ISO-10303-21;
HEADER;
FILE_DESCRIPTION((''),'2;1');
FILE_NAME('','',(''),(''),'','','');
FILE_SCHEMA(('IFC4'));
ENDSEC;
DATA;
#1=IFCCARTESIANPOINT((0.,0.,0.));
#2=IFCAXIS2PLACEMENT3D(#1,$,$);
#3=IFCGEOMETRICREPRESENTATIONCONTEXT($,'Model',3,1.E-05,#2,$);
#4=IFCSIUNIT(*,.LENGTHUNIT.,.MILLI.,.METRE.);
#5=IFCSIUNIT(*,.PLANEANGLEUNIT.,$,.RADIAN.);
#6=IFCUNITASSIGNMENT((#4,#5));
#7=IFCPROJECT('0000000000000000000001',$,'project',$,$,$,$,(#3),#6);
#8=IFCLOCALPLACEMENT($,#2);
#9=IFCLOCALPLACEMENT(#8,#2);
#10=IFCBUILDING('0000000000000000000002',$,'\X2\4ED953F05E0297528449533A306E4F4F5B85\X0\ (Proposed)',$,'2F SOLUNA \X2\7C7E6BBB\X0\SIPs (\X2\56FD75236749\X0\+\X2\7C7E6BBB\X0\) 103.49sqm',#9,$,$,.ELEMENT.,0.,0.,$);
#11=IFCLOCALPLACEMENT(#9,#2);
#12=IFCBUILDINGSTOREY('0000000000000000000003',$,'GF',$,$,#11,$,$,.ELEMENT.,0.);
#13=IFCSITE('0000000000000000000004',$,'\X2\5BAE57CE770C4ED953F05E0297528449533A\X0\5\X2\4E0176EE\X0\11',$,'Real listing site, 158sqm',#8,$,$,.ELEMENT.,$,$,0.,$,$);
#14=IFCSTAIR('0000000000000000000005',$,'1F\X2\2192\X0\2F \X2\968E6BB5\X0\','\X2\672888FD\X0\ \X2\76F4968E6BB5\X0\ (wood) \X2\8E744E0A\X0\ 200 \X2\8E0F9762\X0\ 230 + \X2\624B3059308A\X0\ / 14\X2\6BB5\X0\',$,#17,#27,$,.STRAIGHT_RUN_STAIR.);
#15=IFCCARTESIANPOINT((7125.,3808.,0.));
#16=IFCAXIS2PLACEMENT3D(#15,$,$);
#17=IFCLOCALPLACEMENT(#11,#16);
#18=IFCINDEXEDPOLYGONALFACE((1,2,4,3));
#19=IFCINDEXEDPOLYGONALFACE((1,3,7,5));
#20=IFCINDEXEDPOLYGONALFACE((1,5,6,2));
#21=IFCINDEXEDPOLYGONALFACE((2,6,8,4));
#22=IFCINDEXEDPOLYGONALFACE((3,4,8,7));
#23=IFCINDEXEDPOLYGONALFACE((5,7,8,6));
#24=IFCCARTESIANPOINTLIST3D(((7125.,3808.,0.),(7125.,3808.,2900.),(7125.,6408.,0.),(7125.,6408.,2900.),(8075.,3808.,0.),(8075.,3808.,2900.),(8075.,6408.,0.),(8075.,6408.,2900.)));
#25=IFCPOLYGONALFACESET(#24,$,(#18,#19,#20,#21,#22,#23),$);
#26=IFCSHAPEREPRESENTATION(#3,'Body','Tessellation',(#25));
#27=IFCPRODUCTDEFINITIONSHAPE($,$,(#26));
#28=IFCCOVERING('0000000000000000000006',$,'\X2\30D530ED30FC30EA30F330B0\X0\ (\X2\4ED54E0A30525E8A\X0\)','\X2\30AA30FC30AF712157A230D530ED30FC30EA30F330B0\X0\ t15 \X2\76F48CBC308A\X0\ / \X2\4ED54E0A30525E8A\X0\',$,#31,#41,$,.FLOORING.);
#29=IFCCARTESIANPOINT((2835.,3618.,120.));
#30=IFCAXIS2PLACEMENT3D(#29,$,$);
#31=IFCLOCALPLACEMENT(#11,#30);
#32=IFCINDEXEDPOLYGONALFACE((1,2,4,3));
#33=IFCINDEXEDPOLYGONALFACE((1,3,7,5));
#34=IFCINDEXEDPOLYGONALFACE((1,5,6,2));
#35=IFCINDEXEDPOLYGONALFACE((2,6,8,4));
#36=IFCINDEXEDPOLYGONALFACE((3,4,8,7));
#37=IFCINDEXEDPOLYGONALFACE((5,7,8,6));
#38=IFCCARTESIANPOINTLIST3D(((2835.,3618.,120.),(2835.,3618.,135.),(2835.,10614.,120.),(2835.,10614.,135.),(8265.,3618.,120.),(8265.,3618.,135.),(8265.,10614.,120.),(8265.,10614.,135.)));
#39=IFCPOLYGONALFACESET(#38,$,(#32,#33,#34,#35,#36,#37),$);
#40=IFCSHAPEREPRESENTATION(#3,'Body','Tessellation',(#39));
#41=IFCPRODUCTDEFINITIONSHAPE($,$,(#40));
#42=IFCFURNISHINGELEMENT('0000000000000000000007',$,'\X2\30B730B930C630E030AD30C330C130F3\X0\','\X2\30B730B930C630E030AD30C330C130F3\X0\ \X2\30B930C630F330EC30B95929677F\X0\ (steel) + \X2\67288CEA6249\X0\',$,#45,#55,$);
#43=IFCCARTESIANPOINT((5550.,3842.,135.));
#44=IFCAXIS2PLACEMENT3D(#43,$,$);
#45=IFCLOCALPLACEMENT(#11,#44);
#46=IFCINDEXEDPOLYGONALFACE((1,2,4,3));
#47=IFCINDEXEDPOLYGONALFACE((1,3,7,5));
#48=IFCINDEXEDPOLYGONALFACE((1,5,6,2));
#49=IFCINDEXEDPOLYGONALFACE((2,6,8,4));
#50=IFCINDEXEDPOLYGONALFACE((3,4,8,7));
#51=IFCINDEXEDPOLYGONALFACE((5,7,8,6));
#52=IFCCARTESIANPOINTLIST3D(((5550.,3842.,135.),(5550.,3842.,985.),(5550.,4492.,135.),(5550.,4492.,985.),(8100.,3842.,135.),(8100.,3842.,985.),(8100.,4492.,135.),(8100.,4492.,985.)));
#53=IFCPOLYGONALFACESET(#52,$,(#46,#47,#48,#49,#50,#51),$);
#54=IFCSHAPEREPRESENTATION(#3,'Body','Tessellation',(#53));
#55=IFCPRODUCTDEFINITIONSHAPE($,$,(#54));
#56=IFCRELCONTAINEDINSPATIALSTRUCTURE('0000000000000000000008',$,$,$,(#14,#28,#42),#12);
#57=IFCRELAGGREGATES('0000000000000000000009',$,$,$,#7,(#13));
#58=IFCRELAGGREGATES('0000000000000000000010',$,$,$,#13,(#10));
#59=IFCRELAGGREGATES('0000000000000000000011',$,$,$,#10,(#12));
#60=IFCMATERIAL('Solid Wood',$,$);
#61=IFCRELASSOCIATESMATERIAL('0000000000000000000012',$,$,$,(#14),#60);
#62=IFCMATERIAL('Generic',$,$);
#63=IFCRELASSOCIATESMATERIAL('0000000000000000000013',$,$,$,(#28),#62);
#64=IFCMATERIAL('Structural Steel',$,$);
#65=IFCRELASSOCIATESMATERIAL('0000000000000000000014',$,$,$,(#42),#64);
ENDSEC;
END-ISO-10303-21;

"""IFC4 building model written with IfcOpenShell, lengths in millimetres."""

from ifc_helpers import new_model, si_unit, frame, frame_2d, origin, place, context, project, spatial, rectangle, extrude, material, element, save


model = new_model("IFC4")

# Units and contexts
model_context = context("Model", 3, precision=1e-05, world=origin())
ifc_project = project(units=[si_unit("LENGTHUNIT", "METRE", prefix="MILLI"), si_unit("PLANEANGLEUNIT", "RADIAN")], contexts=[model_context])

# Site, building, storey
site_placement = place(None, origin())
site = spatial("IfcSite", under=ifc_project, at=site_placement, Name="宮城県仙台市青葉区5丁目11", ObjectType="Real listing site, 158sqm", CompositionType="ELEMENT", RefElevation=0.0)
building_placement = place(site_placement, origin())
building = spatial("IfcBuilding", under=site, at=building_placement, Name="仙台市青葉区の住宅 (Proposed)", ObjectType="2F SOLUNA 籾殻SIPs (国産杉+籾殻) 103.49sqm", CompositionType="ELEMENT", ElevationOfRefHeight=0.0, ElevationOfTerrain=0.0)
storey_placement = place(building_placement, origin())
storey = spatial("IfcBuildingStorey", under=building, at=storey_placement, Name="GF", CompositionType="ELEMENT", Elevation=0.0)

# Shared definitions
ifc_material_1 = material(Name="Solid Wood")
ifc_material_2 = material(Name="Generic")

# Stair
stair_placement = place(storey_placement, frame((7125.0, 3808.0, 0.0)))
element("IfcStair", 1, at=stair_placement, inside=storey, material=ifc_material_1, Name="1F→2F 階段", Description="木製 直階段 (wood) 蹴上 200 踏面 230 + 手すり / 14段", PredefinedType="STRAIGHT_RUN_STAIR", context=model_context, shape_type="SweptSolid", body=[
    extrude(rectangle(XDim=950.0, YDim=2600.0, at=frame_2d((475.0, 1300.0))), frame((7125.0, 3808.0, 0.0)), (0.0, 0.0, 1.0), 2900.0),
])

# Covering
covering_placement = place(storey_placement, frame((2835.0, 3618.0, 120.0)))
element("IfcCovering", 2, at=covering_placement, inside=storey, material=ifc_material_2, Name="フローリング (仕上げ床)", Description="オーク無垢フローリング t15 直貼り / 仕上げ床", PredefinedType="FLOORING", context=model_context, shape_type="SweptSolid", body=[
    extrude(rectangle(XDim=5430.0, YDim=6996.0, at=frame_2d((2715.0, 3498.0))), frame((2835.0, 3618.0, 120.0)), (0.0, 0.0, 1.0), 15.0),
])

# Furnishing element
ifc_material_3 = material(Name="Structural Steel")
furnishing_placement = place(storey_placement, frame((5550.0, 3842.0, 135.0)))
element("IfcFurnishingElement", 3, at=furnishing_placement, inside=storey, material=ifc_material_3, Name="システムキッチン", Description="システムキッチン ステンレス天板 (steel) + 木質扉", context=model_context, shape_type="SweptSolid", body=[
    extrude(rectangle(XDim=2550.0, YDim=650.0, at=frame_2d((1275.0, 325.0))), frame((5550.0, 3842.0, 135.0)), (0.0, 0.0, 1.0), 850.0),
])

save(model, "model.ifc")
